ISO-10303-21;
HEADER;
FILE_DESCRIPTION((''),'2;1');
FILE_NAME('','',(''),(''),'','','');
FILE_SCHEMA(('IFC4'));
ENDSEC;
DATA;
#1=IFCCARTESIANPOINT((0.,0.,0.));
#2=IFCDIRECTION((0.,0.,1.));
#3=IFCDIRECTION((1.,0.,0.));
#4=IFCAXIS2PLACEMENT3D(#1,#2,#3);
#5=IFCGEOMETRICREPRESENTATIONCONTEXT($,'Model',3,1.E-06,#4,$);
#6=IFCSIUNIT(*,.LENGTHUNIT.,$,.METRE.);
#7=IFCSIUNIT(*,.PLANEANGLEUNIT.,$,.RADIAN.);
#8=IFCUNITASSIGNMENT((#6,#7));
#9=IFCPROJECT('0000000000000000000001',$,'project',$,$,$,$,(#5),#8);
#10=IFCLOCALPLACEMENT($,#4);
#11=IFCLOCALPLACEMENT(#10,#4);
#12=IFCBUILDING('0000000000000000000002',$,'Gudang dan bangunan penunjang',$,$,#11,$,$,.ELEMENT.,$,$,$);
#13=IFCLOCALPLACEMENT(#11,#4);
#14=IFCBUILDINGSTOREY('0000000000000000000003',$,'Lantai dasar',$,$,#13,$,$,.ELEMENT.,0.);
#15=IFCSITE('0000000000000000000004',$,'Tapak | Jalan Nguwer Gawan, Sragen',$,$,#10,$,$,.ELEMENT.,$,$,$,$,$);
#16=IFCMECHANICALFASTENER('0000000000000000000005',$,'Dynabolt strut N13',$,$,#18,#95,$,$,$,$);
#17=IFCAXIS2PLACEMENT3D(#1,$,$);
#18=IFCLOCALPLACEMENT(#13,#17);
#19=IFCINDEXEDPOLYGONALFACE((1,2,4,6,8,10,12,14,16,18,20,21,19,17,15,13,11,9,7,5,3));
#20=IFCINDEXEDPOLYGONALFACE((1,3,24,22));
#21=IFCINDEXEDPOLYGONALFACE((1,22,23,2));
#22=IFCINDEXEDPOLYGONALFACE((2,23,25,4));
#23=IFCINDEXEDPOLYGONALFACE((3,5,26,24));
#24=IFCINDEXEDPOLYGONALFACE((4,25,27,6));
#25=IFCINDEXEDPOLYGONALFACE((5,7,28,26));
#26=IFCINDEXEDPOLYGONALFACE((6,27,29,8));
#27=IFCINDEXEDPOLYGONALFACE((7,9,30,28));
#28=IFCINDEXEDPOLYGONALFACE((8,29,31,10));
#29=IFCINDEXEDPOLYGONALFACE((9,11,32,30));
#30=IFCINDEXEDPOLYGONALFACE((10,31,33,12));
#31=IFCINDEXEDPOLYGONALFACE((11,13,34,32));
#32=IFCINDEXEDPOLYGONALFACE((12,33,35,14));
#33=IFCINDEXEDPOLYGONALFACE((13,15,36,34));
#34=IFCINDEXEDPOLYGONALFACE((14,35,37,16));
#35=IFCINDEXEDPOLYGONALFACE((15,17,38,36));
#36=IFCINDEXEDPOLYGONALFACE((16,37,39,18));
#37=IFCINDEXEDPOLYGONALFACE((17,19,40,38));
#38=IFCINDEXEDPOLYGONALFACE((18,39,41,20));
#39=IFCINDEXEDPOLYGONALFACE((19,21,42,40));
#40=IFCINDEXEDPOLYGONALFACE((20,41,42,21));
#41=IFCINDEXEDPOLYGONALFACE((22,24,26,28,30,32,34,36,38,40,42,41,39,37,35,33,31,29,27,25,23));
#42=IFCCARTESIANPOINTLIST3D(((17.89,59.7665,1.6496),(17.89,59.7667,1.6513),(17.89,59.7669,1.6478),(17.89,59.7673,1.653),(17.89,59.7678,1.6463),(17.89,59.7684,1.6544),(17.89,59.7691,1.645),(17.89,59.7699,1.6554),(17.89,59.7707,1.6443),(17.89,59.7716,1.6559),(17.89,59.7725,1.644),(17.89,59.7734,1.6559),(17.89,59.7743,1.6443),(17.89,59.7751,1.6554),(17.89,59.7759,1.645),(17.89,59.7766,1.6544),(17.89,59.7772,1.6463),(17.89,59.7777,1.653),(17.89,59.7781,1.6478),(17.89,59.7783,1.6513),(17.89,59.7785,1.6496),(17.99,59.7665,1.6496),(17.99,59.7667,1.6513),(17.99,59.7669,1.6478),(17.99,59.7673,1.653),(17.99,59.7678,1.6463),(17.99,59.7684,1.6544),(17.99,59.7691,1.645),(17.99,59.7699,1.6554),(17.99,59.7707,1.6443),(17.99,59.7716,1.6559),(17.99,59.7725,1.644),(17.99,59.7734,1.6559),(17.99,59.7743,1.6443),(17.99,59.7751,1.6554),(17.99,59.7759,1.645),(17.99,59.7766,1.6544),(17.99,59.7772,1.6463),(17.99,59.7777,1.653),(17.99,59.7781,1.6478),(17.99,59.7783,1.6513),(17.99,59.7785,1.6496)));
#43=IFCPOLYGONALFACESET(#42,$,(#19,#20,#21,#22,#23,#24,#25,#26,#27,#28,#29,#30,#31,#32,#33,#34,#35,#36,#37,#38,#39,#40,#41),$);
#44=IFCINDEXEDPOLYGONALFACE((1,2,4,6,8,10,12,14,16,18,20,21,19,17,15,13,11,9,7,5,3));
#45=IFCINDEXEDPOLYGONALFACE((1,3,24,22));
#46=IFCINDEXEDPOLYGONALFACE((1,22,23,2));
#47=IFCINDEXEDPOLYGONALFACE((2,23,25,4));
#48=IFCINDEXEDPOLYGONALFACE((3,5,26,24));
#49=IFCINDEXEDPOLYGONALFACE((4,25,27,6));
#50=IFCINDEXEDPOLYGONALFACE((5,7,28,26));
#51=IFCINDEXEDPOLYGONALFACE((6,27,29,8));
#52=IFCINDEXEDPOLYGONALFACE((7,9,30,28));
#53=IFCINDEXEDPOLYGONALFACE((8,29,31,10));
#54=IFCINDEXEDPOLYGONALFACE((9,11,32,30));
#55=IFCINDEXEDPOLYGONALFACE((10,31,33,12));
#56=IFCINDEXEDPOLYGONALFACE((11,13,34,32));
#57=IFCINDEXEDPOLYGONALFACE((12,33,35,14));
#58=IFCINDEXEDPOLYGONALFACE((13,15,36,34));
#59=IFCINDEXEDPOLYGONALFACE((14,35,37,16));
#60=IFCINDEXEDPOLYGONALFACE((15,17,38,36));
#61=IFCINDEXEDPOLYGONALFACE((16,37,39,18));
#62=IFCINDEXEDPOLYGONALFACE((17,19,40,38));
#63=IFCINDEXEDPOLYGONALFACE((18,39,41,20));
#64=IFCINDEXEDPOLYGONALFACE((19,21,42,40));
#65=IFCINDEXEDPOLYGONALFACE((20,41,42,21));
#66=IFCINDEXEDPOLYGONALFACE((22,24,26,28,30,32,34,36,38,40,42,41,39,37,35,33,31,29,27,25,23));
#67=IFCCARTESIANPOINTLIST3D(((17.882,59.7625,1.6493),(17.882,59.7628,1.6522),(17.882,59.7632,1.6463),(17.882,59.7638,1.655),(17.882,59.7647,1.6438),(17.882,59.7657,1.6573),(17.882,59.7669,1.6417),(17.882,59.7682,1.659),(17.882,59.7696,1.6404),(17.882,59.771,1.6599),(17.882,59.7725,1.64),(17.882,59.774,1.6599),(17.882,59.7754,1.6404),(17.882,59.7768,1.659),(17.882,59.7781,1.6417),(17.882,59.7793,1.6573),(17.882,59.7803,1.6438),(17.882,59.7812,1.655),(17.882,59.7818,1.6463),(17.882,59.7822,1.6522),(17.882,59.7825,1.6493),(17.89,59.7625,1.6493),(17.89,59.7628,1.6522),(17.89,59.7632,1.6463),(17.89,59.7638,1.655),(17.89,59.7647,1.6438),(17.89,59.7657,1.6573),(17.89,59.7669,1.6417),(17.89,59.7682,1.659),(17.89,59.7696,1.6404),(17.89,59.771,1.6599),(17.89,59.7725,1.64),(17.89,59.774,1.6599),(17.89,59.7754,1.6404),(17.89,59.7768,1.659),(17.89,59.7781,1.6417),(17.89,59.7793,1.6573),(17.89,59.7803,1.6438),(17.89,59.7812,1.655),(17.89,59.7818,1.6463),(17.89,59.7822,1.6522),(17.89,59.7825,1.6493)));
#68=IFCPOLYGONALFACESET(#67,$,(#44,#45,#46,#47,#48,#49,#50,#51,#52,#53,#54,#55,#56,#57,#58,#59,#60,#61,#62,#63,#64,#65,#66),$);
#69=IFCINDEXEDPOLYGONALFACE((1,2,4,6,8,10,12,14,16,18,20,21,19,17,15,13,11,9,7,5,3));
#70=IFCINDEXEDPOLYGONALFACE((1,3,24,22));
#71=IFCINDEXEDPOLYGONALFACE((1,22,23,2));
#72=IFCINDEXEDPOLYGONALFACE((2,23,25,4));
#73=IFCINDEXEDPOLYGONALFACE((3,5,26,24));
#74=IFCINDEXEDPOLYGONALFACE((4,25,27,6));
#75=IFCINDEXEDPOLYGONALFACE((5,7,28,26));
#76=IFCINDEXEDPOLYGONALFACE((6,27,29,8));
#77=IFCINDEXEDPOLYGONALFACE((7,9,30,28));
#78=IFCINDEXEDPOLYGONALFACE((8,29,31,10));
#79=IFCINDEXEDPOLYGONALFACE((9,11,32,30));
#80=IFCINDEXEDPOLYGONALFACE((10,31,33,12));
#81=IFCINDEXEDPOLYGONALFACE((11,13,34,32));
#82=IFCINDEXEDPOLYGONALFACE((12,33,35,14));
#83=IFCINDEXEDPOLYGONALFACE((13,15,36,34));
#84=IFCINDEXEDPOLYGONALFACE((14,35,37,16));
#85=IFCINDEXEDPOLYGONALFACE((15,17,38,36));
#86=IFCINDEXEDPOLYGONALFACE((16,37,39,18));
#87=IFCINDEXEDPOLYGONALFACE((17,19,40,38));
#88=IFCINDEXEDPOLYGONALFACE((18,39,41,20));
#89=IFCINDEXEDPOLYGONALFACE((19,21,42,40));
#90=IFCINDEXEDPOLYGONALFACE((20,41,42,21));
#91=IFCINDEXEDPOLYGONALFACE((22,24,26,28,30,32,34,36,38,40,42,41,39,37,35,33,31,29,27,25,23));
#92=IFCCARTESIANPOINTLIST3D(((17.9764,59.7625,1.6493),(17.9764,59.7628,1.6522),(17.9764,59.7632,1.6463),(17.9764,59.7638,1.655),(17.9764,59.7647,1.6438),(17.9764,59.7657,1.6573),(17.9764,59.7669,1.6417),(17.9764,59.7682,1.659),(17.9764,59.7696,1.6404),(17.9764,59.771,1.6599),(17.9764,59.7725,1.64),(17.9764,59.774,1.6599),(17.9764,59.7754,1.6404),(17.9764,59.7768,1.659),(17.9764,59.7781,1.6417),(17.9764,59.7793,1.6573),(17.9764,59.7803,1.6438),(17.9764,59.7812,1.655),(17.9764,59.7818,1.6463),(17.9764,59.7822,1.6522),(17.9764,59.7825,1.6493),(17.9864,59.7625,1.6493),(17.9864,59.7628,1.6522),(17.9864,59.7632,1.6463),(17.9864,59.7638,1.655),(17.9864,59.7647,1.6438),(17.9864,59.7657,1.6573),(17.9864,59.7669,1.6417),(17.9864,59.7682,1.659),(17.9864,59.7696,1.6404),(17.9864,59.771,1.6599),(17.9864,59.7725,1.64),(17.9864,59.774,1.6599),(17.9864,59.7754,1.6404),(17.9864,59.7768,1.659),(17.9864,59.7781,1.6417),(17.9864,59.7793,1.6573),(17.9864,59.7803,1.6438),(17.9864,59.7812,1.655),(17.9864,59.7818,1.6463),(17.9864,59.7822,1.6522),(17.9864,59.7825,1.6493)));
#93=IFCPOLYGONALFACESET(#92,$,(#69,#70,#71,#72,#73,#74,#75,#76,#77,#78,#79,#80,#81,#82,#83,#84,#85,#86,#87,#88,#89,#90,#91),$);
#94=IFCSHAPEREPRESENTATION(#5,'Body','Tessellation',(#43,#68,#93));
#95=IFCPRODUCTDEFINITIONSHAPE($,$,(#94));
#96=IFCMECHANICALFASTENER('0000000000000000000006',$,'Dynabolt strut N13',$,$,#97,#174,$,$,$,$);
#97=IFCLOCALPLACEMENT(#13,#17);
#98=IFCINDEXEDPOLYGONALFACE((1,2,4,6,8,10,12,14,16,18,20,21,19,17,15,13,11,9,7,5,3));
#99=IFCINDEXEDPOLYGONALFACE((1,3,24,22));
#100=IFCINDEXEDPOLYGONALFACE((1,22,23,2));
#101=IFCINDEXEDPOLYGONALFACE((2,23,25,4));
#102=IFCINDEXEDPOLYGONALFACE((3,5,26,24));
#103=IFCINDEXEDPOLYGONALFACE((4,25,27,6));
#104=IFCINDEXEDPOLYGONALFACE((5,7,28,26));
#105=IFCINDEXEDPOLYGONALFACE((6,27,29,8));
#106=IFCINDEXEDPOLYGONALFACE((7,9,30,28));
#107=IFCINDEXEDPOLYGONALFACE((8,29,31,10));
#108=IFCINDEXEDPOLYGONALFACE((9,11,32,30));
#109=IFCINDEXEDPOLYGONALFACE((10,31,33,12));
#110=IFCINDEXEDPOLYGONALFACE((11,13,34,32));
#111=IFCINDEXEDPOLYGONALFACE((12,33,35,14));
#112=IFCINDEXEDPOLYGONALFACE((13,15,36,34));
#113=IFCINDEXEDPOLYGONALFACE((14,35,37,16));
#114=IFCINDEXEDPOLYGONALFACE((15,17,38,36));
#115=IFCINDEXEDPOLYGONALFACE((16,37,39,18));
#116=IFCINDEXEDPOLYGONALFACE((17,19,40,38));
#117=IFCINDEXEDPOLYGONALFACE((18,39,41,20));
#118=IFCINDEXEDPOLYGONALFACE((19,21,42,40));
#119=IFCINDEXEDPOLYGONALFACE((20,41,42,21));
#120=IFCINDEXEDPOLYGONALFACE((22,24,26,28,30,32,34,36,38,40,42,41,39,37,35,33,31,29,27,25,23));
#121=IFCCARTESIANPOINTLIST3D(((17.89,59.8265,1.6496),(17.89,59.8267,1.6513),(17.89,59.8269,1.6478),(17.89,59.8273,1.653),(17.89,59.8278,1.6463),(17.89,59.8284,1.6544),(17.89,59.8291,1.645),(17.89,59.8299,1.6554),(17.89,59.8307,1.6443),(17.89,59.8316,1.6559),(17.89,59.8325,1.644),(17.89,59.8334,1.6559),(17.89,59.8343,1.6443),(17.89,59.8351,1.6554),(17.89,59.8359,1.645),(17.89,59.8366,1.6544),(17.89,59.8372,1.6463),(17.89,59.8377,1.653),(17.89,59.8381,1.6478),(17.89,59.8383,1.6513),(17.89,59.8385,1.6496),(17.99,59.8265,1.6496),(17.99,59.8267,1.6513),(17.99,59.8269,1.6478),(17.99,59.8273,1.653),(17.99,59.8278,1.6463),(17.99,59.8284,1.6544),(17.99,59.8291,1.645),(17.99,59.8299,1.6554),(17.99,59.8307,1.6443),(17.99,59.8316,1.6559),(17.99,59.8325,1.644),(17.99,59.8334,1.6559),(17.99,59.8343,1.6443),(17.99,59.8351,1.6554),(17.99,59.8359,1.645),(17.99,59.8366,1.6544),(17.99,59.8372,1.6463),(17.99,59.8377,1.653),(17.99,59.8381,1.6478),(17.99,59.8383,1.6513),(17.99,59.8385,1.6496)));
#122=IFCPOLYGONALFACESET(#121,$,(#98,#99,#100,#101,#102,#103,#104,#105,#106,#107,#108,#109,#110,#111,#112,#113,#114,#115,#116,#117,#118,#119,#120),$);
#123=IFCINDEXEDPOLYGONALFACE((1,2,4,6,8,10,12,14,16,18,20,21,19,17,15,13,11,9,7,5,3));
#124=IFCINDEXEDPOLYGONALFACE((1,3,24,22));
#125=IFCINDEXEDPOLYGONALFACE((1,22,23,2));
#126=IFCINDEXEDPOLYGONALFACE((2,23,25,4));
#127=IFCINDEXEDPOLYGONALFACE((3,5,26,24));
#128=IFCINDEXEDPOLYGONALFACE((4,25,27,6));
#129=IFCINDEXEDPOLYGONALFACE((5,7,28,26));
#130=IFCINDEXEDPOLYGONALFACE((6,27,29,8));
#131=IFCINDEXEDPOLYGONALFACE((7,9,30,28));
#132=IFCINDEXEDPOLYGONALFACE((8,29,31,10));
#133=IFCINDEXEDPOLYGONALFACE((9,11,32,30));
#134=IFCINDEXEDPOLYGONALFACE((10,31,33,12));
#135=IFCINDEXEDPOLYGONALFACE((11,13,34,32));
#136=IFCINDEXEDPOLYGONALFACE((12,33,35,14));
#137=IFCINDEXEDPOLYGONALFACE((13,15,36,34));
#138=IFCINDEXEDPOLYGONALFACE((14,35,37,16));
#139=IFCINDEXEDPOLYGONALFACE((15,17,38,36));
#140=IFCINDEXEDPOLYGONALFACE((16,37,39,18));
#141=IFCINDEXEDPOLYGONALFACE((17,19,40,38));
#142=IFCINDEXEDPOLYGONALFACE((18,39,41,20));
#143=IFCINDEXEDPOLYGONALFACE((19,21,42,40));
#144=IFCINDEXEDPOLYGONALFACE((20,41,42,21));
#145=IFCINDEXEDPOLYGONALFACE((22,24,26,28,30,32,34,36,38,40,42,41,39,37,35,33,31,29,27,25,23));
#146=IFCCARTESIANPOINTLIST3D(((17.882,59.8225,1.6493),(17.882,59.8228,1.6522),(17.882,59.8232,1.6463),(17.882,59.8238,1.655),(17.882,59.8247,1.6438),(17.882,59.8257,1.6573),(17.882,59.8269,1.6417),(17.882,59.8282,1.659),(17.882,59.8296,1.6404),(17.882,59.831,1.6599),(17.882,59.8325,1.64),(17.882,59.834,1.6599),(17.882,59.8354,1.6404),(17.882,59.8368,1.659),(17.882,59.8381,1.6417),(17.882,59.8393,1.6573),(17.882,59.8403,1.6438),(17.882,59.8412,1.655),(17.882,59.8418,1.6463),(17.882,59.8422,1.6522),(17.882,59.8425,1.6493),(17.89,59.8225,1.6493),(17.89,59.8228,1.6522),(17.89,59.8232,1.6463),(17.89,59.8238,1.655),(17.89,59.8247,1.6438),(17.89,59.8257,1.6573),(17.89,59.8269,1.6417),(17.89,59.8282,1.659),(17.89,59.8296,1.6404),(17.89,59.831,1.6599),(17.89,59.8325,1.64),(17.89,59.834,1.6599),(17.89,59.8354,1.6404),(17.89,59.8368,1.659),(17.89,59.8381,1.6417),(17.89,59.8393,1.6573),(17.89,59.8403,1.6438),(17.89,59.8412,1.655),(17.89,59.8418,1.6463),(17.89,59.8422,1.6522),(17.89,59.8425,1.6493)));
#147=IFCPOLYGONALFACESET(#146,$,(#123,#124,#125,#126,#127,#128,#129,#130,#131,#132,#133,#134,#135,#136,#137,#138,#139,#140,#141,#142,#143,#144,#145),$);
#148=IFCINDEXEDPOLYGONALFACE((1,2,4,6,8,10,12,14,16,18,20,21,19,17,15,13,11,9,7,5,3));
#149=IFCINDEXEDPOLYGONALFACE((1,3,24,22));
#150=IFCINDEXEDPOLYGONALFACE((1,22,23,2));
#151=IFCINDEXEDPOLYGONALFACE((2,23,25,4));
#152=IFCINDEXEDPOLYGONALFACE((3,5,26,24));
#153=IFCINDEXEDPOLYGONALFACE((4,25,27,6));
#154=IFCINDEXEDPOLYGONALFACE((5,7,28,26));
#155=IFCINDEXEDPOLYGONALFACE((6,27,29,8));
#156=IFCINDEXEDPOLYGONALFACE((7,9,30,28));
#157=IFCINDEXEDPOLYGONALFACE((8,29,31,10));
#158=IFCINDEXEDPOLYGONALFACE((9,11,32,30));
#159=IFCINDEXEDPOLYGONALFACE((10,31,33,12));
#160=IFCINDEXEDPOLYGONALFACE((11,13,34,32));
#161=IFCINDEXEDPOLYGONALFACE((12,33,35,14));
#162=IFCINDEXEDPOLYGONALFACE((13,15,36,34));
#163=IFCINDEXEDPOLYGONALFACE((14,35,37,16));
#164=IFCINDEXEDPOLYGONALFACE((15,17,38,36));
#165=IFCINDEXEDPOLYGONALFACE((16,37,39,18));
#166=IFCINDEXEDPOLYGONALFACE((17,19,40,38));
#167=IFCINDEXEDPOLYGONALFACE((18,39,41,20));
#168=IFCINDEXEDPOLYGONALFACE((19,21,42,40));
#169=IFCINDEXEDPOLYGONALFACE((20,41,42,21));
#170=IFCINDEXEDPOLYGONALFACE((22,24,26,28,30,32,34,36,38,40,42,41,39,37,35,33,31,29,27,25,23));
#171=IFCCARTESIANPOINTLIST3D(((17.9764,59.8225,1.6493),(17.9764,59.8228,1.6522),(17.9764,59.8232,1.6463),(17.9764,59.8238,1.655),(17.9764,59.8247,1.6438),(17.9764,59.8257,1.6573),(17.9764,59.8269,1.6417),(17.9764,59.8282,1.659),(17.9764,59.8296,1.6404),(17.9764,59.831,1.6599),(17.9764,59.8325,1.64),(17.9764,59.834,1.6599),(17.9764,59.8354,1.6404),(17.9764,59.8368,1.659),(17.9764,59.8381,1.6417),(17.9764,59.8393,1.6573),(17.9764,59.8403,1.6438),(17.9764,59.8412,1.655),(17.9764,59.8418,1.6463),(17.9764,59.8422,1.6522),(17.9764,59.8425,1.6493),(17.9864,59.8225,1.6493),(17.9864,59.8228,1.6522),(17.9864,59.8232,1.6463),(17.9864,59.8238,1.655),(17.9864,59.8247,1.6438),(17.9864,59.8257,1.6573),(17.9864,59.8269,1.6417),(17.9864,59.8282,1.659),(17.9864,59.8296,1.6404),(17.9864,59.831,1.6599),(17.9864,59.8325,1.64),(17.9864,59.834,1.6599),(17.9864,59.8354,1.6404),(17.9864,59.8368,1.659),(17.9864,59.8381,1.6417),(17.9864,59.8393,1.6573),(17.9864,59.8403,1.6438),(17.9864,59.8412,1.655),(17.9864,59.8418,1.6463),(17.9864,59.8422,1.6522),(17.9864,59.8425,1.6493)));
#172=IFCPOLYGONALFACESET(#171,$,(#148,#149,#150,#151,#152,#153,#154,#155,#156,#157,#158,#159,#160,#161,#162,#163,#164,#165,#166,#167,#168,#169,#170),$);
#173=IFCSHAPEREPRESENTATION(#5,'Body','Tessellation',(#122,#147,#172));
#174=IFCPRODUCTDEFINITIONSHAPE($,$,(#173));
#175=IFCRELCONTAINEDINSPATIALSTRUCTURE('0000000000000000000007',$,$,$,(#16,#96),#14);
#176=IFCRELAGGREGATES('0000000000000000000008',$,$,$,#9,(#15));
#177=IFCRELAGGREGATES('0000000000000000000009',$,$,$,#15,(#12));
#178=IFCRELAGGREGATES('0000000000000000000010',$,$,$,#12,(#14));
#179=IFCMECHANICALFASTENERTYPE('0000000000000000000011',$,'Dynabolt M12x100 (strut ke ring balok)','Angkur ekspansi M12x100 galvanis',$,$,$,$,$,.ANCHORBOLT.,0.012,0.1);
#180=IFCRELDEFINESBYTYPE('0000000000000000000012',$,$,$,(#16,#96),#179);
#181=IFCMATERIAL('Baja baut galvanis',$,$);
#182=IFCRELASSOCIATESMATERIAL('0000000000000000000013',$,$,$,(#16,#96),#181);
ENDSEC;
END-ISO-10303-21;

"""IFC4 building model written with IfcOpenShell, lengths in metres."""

from ifc_helpers import new_model, si_unit, frame, origin_with_axes, place, context, project, spatial, circle, extrude, source, transform, mapped, material, type_object, type_shapes, element, save


model = new_model("IFC4")

# Units and contexts
model_context = context("Model", 3, precision=1e-06, world=origin_with_axes())
ifc_project = project(units=[si_unit("LENGTHUNIT", "METRE"), si_unit("PLANEANGLEUNIT", "RADIAN")], contexts=[model_context])

# Site, building, storey
site_placement = place(None, origin_with_axes())
site = spatial("IfcSite", under=ifc_project, at=site_placement, Name="Tapak | Jalan Nguwer Gawan, Sragen", CompositionType="ELEMENT")
building_placement = place(site_placement, origin_with_axes())
building = spatial("IfcBuilding", under=site, at=building_placement, Name="Gudang dan bangunan penunjang", CompositionType="ELEMENT")
storey_placement = place(building_placement, origin_with_axes())
storey = spatial("IfcBuildingStorey", under=building, at=storey_placement, Name="Lantai dasar", CompositionType="ELEMENT", Elevation=0.0)

# Mechanical fasteners
ifc_material = material(Name="Baja baut galvanis")
mechanical_fastener_type = type_object("IfcMechanicalFastenerType", Name="Dynabolt M12x100 (strut ke ring balok)", Description="Angkur ekspansi M12x100 galvanis", NominalDiameter=0.012, NominalLength=0.1, PredefinedType="ANCHORBOLT")
shared_shape = source(origin_with_axes(), model_context, "Body", "SweptSolid", [
    extrude(circle(Radius=0.006), origin_with_axes(), (0.0, 0.0, 1.0), 0.1),
    extrude(circle(Radius=0.01), frame((0.0, 0.0, -0.008), z_axis=(0.0, 0.0, 1.0), x_axis=(1.0, 0.0, 0.0)), (0.0, 0.0, 1.0), 0.008),
    extrude(circle(Radius=0.01), frame((0.0, 0.0, 0.0864), z_axis=(0.0, 0.0, 1.0), x_axis=(1.0, 0.0, 0.0)), (0.0, 0.0, 1.0), 0.01),
])
type_shapes(mechanical_fastener_type, [shared_shape])
placement = place(None, origin_with_axes())
element("IfcMechanicalFastener", 1, at=placement, inside=storey, type_object=mechanical_fastener_type, material=ifc_material, Name="Dynabolt strut N13", context=model_context, shape_type="MappedRepresentation", body=[
    mapped(shared_shape, transform((17.89, 59.7725, 1.65), x_axis=(0.0, 0.0, -1.0), y_axis=(0.0, 1.0, 0.0), z_axis=(1.0, 0.0, 0.0), scale=1.0)),
])
element("IfcMechanicalFastener", 2, at=placement, inside=storey, type_object=mechanical_fastener_type, material=ifc_material, Name="Dynabolt strut N13", context=model_context, shape_type="MappedRepresentation", body=[
    mapped(shared_shape, transform((17.89, 59.8325, 1.65), x_axis=(0.0, 0.0, -1.0), y_axis=(0.0, 1.0, 0.0), z_axis=(1.0, 0.0, 0.0), scale=1.0)),
])

save(model, "model.ifc")
